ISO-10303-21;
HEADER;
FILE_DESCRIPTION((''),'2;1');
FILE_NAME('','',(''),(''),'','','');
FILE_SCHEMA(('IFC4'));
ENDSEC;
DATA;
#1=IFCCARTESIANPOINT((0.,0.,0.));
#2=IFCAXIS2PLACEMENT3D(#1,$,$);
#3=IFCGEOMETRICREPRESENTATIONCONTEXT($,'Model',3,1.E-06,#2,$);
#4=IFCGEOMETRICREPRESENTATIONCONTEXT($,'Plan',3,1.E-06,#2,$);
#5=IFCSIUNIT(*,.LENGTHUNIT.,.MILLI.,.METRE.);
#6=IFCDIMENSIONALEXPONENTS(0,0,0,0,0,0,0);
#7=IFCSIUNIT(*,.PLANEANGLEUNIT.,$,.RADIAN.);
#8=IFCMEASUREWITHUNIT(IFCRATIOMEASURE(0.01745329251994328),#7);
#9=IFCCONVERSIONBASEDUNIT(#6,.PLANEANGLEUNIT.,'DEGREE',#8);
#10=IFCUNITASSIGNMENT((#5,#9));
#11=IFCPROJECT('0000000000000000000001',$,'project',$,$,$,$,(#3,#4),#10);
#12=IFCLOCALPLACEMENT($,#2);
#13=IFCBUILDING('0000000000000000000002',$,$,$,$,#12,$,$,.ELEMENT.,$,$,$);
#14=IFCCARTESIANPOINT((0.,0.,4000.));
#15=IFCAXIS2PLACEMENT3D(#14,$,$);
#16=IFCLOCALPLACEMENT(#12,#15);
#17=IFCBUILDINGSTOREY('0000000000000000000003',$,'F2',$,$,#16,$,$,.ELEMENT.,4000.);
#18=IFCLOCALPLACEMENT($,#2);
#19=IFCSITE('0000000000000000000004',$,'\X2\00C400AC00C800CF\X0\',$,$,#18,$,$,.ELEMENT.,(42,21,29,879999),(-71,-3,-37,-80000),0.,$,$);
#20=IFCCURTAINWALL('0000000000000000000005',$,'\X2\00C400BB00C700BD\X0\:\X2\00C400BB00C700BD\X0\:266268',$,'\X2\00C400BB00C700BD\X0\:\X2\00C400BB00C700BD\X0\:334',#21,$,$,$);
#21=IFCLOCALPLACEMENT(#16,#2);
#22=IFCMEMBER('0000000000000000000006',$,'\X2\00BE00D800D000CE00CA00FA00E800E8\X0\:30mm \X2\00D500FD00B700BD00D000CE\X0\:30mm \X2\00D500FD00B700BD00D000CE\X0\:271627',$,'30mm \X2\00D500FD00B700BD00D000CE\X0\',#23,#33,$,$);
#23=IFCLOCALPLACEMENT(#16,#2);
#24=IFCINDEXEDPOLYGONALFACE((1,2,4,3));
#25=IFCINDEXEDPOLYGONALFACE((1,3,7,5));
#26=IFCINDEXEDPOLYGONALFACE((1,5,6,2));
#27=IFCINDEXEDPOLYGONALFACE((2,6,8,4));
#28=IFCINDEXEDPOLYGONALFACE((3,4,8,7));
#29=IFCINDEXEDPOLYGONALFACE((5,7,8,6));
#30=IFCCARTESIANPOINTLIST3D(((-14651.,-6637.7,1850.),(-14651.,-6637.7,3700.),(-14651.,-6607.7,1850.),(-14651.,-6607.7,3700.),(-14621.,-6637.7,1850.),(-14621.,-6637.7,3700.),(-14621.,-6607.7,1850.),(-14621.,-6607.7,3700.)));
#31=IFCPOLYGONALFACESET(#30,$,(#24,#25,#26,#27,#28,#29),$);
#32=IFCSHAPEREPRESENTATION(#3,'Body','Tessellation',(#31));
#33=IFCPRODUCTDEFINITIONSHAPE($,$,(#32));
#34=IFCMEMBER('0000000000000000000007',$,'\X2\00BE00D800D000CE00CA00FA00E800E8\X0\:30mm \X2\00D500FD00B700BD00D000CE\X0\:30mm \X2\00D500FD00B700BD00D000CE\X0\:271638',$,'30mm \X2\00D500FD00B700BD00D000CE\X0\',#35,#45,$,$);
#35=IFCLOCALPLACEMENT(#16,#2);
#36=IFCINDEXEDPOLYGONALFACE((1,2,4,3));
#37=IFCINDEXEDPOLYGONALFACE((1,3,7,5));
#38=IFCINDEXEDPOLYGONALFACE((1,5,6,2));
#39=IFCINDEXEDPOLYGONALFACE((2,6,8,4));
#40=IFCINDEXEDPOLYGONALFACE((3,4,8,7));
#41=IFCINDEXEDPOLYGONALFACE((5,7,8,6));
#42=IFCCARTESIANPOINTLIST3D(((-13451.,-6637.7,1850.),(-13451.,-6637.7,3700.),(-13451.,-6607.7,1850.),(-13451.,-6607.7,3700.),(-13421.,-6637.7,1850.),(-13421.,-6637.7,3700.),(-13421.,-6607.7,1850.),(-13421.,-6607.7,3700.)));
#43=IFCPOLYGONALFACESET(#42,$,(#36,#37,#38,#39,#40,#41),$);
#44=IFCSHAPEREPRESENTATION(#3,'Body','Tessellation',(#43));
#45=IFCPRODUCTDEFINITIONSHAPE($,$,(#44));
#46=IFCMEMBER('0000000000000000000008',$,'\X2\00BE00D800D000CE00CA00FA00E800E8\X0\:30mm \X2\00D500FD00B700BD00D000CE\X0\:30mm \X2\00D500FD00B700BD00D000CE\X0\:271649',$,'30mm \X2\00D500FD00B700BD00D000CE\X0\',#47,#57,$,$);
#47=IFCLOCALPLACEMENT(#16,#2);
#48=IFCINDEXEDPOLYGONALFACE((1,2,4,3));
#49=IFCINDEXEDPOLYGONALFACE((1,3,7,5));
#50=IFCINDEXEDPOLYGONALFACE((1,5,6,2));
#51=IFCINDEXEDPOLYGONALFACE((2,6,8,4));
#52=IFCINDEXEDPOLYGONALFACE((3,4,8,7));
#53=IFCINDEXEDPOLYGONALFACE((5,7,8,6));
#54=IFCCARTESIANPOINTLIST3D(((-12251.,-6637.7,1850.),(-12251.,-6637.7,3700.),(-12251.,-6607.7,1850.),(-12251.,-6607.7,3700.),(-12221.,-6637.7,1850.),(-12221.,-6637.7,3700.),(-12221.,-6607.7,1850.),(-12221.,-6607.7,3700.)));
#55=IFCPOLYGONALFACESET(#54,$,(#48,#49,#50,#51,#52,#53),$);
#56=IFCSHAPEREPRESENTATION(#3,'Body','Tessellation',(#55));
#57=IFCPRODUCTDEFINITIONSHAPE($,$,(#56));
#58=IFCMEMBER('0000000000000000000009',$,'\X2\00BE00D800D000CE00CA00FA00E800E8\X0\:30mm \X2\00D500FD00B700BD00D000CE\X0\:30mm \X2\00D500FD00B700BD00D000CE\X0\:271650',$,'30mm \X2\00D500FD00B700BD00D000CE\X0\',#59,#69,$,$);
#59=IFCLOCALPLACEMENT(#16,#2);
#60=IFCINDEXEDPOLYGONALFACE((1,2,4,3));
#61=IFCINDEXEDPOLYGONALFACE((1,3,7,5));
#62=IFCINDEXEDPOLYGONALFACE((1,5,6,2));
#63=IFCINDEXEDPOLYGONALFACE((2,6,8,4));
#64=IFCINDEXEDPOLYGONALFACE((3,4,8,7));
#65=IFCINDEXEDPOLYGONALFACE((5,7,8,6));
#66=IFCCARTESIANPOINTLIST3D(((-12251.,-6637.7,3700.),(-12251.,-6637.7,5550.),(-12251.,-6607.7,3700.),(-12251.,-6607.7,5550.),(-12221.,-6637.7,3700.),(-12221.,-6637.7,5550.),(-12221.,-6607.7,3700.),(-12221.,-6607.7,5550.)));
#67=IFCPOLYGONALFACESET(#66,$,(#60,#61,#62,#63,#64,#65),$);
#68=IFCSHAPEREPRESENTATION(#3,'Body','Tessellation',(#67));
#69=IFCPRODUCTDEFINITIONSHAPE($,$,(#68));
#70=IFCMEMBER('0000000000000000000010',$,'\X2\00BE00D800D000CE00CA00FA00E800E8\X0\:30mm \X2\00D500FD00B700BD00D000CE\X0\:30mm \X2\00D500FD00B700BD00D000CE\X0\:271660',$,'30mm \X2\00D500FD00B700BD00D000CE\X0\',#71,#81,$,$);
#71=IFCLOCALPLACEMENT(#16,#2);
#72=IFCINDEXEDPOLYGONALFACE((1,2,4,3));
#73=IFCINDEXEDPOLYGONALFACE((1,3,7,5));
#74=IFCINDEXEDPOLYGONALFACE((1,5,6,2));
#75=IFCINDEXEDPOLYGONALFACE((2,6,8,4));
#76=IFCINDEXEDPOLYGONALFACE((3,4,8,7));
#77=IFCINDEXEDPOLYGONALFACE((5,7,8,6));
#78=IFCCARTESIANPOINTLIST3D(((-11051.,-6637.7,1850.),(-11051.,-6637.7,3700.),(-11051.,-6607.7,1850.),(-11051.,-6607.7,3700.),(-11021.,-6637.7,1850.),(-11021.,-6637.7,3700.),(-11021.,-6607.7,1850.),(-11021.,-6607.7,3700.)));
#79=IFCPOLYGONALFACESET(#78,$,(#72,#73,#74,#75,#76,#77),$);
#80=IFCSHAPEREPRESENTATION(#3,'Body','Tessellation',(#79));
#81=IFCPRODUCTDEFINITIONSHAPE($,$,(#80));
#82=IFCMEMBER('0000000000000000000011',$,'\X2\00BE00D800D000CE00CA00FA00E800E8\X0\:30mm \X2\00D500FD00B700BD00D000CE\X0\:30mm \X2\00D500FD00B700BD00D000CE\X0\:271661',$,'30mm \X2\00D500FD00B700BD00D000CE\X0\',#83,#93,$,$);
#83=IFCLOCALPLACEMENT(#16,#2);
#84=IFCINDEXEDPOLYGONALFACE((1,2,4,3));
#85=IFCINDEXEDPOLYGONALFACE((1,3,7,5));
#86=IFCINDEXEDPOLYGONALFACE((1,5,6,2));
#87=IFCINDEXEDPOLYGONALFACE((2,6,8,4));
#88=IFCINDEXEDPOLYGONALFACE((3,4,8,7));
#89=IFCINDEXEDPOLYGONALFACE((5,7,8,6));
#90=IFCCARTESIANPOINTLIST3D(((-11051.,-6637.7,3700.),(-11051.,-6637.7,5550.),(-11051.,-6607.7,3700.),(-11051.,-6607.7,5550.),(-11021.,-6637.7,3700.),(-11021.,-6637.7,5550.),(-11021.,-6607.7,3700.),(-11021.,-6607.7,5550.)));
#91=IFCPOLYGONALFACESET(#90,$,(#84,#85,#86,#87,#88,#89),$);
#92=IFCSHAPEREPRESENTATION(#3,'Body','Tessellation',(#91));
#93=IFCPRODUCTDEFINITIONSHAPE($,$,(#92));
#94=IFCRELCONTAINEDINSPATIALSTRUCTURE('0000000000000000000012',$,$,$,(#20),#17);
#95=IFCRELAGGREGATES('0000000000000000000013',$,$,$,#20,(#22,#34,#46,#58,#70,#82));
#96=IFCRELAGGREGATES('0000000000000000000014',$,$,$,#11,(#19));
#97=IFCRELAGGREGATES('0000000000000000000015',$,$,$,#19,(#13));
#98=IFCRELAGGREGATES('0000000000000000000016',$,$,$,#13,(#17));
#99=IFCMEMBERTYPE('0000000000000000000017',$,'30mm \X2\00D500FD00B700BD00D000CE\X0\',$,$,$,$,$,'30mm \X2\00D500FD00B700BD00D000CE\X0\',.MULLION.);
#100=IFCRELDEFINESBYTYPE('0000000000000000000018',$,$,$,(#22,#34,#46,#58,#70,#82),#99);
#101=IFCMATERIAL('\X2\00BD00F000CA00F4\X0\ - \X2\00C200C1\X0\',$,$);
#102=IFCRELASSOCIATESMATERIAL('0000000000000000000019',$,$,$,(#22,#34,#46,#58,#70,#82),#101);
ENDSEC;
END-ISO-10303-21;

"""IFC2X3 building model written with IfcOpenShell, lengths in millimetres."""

from ifc_helpers import new_model, entity, si_unit, converted_unit, frame, origin, origin_2d_with_axis, place, context, project, spatial, rectangle, extrude, source, transform, mapped, material, type_object, type_shapes, element, aggregate, save


model = new_model("IFC2X3")

# Units and contexts
model_context = context("Model", 3, precision=1e-06, world=origin())
plan_context = context("Plan", 3, precision=1e-06, world=origin())
ifc_project = project(units=[si_unit("LENGTHUNIT", "METRE", prefix="MILLI"), converted_unit("PLANEANGLEUNIT", "DEGREE", entity("IfcRatioMeasure", 0.01745329251994328), si_unit("PLANEANGLEUNIT", "RADIAN"), dimensions=[0, 0, 0, 0, 0, 0, 0])], contexts=[model_context, plan_context])

# Site, building, storey
site_placement = place(None, origin())
site = spatial("IfcSite", under=ifc_project, at=site_placement, Name="Ä¬ÈÏ", CompositionType="ELEMENT", RefLatitude=(42, 21, 29, 879999), RefLongitude=(-71, -3, -37, -80000), RefElevation=0.0)
building_placement = place(None, origin())
building = spatial("IfcBuilding", under=site, at=building_placement, CompositionType="ELEMENT")
storey_placement = place(building_placement, frame((0.0, 0.0, 4000.0)))
storey = spatial("IfcBuildingStorey", under=building, at=storey_placement, Name="F2", CompositionType="ELEMENT", Elevation=4000.0)

# Curtain wall, members
curtain_wall_placement = place(storey_placement, origin())
curtain_wall = element("IfcCurtainWall", 1, at=curtain_wall_placement, inside=storey, Name="Ä»Ç½:Ä»Ç½:266268", ObjectType="Ä»Ç½:Ä»Ç½:334")
ifc_material_1 = material(Name="½ðÊô - ÂÁ")
placement = place(building_placement, frame((0.0, 0.0, 7700.0)))
member_type_1 = type_object("IfcMemberType", Name="30mm Õý·½ÐÎ", ElementType="30mm Õý·½ÐÎ", PredefinedType="MULLION")
shared_shape_1 = source(origin(), model_context, "Body", "SweptSolid", [
    extrude(rectangle(XDim=30.0, YDim=30.0, at=origin_2d_with_axis()), frame((0.0, 0.0, -1850.0), z_axis=(0.0, 0.0, 1.0), x_axis=(-1.0, 0.0, 0.0)), (0.0, 0.0, 1.0), 1850.0),
])
type_shapes(member_type_1, [shared_shape_1])
member_1_placement = place(storey_placement, frame((-14636.0, -6622.7, 1850.0), z_axis=(0.0, 0.0, -1.0), x_axis=(1.0, 0.0, 0.0)))
member_1 = element("IfcMember", 2, at=member_1_placement, type_object=member_type_1, material=ifc_material_1, Name="¾ØÐÎÊúèè:30mm Õý·½ÐÎ:30mm Õý·½ÐÎ:271627", ObjectType="30mm Õý·½ÐÎ", context=model_context, shape_type="MappedRepresentation", body=[
    mapped(shared_shape_1, transform((0.0, 0.0, 0.0), scale=1.0)),
])
member_2_placement = place(storey_placement, frame((-13436.0, -6622.7, 1850.0), z_axis=(0.0, 0.0, -1.0), x_axis=(1.0, 0.0, 0.0)))
member_2 = element("IfcMember", 3, at=member_2_placement, type_object=member_type_1, material=ifc_material_1, Name="¾ØÐÎÊúèè:30mm Õý·½ÐÎ:30mm Õý·½ÐÎ:271638", ObjectType="30mm Õý·½ÐÎ", context=model_context, shape_type="MappedRepresentation", body=[
    mapped(shared_shape_1, transform((0.0, 0.0, 0.0), scale=1.0)),
])
member_3_placement = place(storey_placement, frame((-12236.0, -6622.7, 1850.0), z_axis=(0.0, 0.0, -1.0), x_axis=(1.0, 0.0, 0.0)))
member_3 = element("IfcMember", 4, at=member_3_placement, type_object=member_type_1, material=ifc_material_1, Name="¾ØÐÎÊúèè:30mm Õý·½ÐÎ:30mm Õý·½ÐÎ:271649", ObjectType="30mm Õý·½ÐÎ", context=model_context, shape_type="MappedRepresentation", body=[
    mapped(shared_shape_1, transform((0.0, 0.0, 0.0), scale=1.0)),
])
member_4_placement = place(placement, frame((-12236.0, -6622.7, 0.0), z_axis=(0.0, 0.0, -1.0), x_axis=(1.0, 0.0, 0.0)))
member_4 = element("IfcMember", 5, at=member_4_placement, type_object=member_type_1, material=ifc_material_1, Name="¾ØÐÎÊúèè:30mm Õý·½ÐÎ:30mm Õý·½ÐÎ:271650", ObjectType="30mm Õý·½ÐÎ", context=model_context, shape_type="MappedRepresentation", body=[
    mapped(shared_shape_1, transform((0.0, 0.0, 0.0), scale=1.0)),
])
member_5_placement = place(storey_placement, frame((-11036.0, -6622.7, 1850.0), z_axis=(0.0, 0.0, -1.0), x_axis=(1.0, 0.0, 0.0)))
member_5 = element("IfcMember", 6, at=member_5_placement, type_object=member_type_1, material=ifc_material_1, Name="¾ØÐÎÊúèè:30mm Õý·½ÐÎ:30mm Õý·½ÐÎ:271660", ObjectType="30mm Õý·½ÐÎ", context=model_context, shape_type="MappedRepresentation", body=[
    mapped(shared_shape_1, transform((0.0, 0.0, 0.0), scale=1.0)),
])
member_6_placement = place(placement, frame((-11036.0, -6622.7, 0.0), z_axis=(0.0, 0.0, -1.0), x_axis=(1.0, 0.0, 0.0)))
member_6 = element("IfcMember", 7, at=member_6_placement, type_object=member_type_1, material=ifc_material_1, Name="¾ØÐÎÊúèè:30mm Õý·½ÐÎ:30mm Õý·½ÐÎ:271661", ObjectType="30mm Õý·½ÐÎ", context=model_context, shape_type="MappedRepresentation", body=[
    mapped(shared_shape_1, transform((0.0, 0.0, 0.0), scale=1.0)),
])
aggregate(curtain_wall, [member_1, member_2, member_3, member_4, member_5, member_6])

save(model, "model.ifc")
